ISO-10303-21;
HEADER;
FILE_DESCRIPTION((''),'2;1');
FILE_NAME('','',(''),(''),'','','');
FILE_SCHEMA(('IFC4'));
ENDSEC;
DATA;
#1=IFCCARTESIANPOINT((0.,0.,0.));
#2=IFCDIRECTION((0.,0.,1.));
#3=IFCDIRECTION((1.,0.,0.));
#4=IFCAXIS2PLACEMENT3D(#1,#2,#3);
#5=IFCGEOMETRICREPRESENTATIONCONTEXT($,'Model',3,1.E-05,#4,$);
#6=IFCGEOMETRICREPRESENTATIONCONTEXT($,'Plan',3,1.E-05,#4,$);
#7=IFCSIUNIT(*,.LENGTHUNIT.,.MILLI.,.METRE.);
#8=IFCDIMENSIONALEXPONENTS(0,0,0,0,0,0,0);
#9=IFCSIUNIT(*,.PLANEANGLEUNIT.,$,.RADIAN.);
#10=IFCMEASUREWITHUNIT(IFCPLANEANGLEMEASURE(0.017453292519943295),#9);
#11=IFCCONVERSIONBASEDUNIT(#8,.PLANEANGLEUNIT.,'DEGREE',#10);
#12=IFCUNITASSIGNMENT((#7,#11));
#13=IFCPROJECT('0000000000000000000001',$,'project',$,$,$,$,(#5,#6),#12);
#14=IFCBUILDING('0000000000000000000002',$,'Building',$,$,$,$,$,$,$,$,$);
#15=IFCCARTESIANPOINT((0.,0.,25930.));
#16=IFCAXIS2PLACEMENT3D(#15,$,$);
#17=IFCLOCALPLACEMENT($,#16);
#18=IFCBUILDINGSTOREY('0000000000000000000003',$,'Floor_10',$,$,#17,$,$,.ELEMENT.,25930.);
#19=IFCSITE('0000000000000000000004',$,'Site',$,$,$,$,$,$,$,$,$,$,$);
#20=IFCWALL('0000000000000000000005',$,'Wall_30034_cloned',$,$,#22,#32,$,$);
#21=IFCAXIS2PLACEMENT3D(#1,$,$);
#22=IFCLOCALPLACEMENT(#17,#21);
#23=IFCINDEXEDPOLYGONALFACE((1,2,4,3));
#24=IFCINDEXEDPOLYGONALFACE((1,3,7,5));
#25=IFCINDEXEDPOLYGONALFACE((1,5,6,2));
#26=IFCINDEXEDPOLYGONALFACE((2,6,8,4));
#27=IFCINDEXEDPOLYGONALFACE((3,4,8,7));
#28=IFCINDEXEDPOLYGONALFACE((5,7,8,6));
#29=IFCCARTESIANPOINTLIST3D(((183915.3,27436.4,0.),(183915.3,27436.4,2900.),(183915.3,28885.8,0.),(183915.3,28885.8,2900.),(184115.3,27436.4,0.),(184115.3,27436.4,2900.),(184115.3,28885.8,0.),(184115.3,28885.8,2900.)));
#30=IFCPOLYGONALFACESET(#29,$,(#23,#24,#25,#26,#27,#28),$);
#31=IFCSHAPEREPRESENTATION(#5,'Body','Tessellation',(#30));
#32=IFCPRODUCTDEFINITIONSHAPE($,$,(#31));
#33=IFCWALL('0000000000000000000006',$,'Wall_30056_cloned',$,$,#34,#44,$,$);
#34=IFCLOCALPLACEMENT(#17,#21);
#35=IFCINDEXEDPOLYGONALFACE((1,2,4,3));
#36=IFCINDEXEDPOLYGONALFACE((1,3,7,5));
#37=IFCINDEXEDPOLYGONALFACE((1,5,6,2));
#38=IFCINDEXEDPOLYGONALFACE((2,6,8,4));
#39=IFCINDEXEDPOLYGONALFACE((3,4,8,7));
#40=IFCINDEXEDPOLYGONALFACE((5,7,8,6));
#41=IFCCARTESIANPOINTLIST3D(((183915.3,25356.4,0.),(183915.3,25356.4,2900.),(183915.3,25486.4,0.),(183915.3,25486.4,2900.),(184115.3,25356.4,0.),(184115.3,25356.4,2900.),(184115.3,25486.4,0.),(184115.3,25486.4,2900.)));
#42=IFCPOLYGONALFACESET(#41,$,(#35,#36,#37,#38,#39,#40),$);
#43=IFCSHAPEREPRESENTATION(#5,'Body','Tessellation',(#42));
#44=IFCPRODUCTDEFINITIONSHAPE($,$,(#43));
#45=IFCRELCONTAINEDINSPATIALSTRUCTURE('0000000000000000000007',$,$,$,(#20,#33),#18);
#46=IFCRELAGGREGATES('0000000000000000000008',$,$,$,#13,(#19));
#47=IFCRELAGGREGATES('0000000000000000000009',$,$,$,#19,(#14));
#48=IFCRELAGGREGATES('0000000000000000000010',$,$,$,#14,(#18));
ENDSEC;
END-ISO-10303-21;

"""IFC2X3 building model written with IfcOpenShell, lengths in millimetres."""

from ifc_helpers import new_model, entity, si_unit, converted_unit, frame, origin_with_axes, origin_2d, place, context, project, spatial, rectangle, extrude, source, transform, mapped, element, save


model = new_model("IFC2X3")

# Units and contexts
model_context = context("Model", 3, precision=1e-05, world=origin_with_axes())
plan_context = context("Plan", 3, precision=1e-05, world=origin_with_axes())
ifc_project = project(units=[si_unit("LENGTHUNIT", "METRE", prefix="MILLI"), converted_unit("PLANEANGLEUNIT", "DEGREE", entity("IfcPlaneAngleMeasure", 0.017453292519943295), si_unit("PLANEANGLEUNIT", "RADIAN"), dimensions=[0, 0, 0, 0, 0, 0, 0])], contexts=[model_context, plan_context])

# Site, building, storey
site = spatial("IfcSite", under=ifc_project, Name="Site")
building = spatial("IfcBuilding", under=site, Name="Building")
storey_placement = place(None, frame((0.0, 0.0, 25930.0)))
storey = spatial("IfcBuildingStorey", under=building, at=storey_placement, Name="Floor_10", CompositionType="ELEMENT", Elevation=25930.0)

# Walls
shared_shape_1 = source(origin_with_axes(), model_context, "Body", "SweptSolid", [
    extrude(rectangle(XDim=1449.4, YDim=200.0, at=origin_2d()), origin_with_axes(), (0.0, 0.0, 1.0), 2900.0),
])
wall_1_placement = place(storey_placement, frame((184015.3, 28161.1, 0.0), z_axis=(0.0, 0.0, 1.0), x_axis=(0.0, 1449.4128, 0.0)))
element("IfcWall", 1, at=wall_1_placement, inside=storey, Name="Wall_30034_cloned", context=model_context, shape_type="MappedRepresentation", body=[
    mapped(shared_shape_1, transform((0.0, 0.0, 0.0), x_axis=(1.0, 0.0, 0.0), y_axis=(0.0, 1.0, 0.0), z_axis=(0.0, 0.0, 1.0), scale=1.0)),
])
shared_shape_2 = source(origin_with_axes(), model_context, "Body", "SweptSolid", [
    extrude(rectangle(XDim=130.0, YDim=200.0, at=origin_2d()), origin_with_axes(), (0.0, 0.0, 1.0), 2900.0),
])
wall_2_placement = place(storey_placement, frame((184015.3, 25421.4, 0.0), z_axis=(0.0, 0.0, 1.0), x_axis=(0.0, 130.000004, 0.0)))
element("IfcWall", 2, at=wall_2_placement, inside=storey, Name="Wall_30056_cloned", context=model_context, shape_type="MappedRepresentation", body=[
    mapped(shared_shape_2, transform((0.0, 0.0, 0.0), x_axis=(1.0, 0.0, 0.0), y_axis=(0.0, 1.0, 0.0), z_axis=(0.0, 0.0, 1.0), scale=1.0)),
])

save(model, "model.ifc")
